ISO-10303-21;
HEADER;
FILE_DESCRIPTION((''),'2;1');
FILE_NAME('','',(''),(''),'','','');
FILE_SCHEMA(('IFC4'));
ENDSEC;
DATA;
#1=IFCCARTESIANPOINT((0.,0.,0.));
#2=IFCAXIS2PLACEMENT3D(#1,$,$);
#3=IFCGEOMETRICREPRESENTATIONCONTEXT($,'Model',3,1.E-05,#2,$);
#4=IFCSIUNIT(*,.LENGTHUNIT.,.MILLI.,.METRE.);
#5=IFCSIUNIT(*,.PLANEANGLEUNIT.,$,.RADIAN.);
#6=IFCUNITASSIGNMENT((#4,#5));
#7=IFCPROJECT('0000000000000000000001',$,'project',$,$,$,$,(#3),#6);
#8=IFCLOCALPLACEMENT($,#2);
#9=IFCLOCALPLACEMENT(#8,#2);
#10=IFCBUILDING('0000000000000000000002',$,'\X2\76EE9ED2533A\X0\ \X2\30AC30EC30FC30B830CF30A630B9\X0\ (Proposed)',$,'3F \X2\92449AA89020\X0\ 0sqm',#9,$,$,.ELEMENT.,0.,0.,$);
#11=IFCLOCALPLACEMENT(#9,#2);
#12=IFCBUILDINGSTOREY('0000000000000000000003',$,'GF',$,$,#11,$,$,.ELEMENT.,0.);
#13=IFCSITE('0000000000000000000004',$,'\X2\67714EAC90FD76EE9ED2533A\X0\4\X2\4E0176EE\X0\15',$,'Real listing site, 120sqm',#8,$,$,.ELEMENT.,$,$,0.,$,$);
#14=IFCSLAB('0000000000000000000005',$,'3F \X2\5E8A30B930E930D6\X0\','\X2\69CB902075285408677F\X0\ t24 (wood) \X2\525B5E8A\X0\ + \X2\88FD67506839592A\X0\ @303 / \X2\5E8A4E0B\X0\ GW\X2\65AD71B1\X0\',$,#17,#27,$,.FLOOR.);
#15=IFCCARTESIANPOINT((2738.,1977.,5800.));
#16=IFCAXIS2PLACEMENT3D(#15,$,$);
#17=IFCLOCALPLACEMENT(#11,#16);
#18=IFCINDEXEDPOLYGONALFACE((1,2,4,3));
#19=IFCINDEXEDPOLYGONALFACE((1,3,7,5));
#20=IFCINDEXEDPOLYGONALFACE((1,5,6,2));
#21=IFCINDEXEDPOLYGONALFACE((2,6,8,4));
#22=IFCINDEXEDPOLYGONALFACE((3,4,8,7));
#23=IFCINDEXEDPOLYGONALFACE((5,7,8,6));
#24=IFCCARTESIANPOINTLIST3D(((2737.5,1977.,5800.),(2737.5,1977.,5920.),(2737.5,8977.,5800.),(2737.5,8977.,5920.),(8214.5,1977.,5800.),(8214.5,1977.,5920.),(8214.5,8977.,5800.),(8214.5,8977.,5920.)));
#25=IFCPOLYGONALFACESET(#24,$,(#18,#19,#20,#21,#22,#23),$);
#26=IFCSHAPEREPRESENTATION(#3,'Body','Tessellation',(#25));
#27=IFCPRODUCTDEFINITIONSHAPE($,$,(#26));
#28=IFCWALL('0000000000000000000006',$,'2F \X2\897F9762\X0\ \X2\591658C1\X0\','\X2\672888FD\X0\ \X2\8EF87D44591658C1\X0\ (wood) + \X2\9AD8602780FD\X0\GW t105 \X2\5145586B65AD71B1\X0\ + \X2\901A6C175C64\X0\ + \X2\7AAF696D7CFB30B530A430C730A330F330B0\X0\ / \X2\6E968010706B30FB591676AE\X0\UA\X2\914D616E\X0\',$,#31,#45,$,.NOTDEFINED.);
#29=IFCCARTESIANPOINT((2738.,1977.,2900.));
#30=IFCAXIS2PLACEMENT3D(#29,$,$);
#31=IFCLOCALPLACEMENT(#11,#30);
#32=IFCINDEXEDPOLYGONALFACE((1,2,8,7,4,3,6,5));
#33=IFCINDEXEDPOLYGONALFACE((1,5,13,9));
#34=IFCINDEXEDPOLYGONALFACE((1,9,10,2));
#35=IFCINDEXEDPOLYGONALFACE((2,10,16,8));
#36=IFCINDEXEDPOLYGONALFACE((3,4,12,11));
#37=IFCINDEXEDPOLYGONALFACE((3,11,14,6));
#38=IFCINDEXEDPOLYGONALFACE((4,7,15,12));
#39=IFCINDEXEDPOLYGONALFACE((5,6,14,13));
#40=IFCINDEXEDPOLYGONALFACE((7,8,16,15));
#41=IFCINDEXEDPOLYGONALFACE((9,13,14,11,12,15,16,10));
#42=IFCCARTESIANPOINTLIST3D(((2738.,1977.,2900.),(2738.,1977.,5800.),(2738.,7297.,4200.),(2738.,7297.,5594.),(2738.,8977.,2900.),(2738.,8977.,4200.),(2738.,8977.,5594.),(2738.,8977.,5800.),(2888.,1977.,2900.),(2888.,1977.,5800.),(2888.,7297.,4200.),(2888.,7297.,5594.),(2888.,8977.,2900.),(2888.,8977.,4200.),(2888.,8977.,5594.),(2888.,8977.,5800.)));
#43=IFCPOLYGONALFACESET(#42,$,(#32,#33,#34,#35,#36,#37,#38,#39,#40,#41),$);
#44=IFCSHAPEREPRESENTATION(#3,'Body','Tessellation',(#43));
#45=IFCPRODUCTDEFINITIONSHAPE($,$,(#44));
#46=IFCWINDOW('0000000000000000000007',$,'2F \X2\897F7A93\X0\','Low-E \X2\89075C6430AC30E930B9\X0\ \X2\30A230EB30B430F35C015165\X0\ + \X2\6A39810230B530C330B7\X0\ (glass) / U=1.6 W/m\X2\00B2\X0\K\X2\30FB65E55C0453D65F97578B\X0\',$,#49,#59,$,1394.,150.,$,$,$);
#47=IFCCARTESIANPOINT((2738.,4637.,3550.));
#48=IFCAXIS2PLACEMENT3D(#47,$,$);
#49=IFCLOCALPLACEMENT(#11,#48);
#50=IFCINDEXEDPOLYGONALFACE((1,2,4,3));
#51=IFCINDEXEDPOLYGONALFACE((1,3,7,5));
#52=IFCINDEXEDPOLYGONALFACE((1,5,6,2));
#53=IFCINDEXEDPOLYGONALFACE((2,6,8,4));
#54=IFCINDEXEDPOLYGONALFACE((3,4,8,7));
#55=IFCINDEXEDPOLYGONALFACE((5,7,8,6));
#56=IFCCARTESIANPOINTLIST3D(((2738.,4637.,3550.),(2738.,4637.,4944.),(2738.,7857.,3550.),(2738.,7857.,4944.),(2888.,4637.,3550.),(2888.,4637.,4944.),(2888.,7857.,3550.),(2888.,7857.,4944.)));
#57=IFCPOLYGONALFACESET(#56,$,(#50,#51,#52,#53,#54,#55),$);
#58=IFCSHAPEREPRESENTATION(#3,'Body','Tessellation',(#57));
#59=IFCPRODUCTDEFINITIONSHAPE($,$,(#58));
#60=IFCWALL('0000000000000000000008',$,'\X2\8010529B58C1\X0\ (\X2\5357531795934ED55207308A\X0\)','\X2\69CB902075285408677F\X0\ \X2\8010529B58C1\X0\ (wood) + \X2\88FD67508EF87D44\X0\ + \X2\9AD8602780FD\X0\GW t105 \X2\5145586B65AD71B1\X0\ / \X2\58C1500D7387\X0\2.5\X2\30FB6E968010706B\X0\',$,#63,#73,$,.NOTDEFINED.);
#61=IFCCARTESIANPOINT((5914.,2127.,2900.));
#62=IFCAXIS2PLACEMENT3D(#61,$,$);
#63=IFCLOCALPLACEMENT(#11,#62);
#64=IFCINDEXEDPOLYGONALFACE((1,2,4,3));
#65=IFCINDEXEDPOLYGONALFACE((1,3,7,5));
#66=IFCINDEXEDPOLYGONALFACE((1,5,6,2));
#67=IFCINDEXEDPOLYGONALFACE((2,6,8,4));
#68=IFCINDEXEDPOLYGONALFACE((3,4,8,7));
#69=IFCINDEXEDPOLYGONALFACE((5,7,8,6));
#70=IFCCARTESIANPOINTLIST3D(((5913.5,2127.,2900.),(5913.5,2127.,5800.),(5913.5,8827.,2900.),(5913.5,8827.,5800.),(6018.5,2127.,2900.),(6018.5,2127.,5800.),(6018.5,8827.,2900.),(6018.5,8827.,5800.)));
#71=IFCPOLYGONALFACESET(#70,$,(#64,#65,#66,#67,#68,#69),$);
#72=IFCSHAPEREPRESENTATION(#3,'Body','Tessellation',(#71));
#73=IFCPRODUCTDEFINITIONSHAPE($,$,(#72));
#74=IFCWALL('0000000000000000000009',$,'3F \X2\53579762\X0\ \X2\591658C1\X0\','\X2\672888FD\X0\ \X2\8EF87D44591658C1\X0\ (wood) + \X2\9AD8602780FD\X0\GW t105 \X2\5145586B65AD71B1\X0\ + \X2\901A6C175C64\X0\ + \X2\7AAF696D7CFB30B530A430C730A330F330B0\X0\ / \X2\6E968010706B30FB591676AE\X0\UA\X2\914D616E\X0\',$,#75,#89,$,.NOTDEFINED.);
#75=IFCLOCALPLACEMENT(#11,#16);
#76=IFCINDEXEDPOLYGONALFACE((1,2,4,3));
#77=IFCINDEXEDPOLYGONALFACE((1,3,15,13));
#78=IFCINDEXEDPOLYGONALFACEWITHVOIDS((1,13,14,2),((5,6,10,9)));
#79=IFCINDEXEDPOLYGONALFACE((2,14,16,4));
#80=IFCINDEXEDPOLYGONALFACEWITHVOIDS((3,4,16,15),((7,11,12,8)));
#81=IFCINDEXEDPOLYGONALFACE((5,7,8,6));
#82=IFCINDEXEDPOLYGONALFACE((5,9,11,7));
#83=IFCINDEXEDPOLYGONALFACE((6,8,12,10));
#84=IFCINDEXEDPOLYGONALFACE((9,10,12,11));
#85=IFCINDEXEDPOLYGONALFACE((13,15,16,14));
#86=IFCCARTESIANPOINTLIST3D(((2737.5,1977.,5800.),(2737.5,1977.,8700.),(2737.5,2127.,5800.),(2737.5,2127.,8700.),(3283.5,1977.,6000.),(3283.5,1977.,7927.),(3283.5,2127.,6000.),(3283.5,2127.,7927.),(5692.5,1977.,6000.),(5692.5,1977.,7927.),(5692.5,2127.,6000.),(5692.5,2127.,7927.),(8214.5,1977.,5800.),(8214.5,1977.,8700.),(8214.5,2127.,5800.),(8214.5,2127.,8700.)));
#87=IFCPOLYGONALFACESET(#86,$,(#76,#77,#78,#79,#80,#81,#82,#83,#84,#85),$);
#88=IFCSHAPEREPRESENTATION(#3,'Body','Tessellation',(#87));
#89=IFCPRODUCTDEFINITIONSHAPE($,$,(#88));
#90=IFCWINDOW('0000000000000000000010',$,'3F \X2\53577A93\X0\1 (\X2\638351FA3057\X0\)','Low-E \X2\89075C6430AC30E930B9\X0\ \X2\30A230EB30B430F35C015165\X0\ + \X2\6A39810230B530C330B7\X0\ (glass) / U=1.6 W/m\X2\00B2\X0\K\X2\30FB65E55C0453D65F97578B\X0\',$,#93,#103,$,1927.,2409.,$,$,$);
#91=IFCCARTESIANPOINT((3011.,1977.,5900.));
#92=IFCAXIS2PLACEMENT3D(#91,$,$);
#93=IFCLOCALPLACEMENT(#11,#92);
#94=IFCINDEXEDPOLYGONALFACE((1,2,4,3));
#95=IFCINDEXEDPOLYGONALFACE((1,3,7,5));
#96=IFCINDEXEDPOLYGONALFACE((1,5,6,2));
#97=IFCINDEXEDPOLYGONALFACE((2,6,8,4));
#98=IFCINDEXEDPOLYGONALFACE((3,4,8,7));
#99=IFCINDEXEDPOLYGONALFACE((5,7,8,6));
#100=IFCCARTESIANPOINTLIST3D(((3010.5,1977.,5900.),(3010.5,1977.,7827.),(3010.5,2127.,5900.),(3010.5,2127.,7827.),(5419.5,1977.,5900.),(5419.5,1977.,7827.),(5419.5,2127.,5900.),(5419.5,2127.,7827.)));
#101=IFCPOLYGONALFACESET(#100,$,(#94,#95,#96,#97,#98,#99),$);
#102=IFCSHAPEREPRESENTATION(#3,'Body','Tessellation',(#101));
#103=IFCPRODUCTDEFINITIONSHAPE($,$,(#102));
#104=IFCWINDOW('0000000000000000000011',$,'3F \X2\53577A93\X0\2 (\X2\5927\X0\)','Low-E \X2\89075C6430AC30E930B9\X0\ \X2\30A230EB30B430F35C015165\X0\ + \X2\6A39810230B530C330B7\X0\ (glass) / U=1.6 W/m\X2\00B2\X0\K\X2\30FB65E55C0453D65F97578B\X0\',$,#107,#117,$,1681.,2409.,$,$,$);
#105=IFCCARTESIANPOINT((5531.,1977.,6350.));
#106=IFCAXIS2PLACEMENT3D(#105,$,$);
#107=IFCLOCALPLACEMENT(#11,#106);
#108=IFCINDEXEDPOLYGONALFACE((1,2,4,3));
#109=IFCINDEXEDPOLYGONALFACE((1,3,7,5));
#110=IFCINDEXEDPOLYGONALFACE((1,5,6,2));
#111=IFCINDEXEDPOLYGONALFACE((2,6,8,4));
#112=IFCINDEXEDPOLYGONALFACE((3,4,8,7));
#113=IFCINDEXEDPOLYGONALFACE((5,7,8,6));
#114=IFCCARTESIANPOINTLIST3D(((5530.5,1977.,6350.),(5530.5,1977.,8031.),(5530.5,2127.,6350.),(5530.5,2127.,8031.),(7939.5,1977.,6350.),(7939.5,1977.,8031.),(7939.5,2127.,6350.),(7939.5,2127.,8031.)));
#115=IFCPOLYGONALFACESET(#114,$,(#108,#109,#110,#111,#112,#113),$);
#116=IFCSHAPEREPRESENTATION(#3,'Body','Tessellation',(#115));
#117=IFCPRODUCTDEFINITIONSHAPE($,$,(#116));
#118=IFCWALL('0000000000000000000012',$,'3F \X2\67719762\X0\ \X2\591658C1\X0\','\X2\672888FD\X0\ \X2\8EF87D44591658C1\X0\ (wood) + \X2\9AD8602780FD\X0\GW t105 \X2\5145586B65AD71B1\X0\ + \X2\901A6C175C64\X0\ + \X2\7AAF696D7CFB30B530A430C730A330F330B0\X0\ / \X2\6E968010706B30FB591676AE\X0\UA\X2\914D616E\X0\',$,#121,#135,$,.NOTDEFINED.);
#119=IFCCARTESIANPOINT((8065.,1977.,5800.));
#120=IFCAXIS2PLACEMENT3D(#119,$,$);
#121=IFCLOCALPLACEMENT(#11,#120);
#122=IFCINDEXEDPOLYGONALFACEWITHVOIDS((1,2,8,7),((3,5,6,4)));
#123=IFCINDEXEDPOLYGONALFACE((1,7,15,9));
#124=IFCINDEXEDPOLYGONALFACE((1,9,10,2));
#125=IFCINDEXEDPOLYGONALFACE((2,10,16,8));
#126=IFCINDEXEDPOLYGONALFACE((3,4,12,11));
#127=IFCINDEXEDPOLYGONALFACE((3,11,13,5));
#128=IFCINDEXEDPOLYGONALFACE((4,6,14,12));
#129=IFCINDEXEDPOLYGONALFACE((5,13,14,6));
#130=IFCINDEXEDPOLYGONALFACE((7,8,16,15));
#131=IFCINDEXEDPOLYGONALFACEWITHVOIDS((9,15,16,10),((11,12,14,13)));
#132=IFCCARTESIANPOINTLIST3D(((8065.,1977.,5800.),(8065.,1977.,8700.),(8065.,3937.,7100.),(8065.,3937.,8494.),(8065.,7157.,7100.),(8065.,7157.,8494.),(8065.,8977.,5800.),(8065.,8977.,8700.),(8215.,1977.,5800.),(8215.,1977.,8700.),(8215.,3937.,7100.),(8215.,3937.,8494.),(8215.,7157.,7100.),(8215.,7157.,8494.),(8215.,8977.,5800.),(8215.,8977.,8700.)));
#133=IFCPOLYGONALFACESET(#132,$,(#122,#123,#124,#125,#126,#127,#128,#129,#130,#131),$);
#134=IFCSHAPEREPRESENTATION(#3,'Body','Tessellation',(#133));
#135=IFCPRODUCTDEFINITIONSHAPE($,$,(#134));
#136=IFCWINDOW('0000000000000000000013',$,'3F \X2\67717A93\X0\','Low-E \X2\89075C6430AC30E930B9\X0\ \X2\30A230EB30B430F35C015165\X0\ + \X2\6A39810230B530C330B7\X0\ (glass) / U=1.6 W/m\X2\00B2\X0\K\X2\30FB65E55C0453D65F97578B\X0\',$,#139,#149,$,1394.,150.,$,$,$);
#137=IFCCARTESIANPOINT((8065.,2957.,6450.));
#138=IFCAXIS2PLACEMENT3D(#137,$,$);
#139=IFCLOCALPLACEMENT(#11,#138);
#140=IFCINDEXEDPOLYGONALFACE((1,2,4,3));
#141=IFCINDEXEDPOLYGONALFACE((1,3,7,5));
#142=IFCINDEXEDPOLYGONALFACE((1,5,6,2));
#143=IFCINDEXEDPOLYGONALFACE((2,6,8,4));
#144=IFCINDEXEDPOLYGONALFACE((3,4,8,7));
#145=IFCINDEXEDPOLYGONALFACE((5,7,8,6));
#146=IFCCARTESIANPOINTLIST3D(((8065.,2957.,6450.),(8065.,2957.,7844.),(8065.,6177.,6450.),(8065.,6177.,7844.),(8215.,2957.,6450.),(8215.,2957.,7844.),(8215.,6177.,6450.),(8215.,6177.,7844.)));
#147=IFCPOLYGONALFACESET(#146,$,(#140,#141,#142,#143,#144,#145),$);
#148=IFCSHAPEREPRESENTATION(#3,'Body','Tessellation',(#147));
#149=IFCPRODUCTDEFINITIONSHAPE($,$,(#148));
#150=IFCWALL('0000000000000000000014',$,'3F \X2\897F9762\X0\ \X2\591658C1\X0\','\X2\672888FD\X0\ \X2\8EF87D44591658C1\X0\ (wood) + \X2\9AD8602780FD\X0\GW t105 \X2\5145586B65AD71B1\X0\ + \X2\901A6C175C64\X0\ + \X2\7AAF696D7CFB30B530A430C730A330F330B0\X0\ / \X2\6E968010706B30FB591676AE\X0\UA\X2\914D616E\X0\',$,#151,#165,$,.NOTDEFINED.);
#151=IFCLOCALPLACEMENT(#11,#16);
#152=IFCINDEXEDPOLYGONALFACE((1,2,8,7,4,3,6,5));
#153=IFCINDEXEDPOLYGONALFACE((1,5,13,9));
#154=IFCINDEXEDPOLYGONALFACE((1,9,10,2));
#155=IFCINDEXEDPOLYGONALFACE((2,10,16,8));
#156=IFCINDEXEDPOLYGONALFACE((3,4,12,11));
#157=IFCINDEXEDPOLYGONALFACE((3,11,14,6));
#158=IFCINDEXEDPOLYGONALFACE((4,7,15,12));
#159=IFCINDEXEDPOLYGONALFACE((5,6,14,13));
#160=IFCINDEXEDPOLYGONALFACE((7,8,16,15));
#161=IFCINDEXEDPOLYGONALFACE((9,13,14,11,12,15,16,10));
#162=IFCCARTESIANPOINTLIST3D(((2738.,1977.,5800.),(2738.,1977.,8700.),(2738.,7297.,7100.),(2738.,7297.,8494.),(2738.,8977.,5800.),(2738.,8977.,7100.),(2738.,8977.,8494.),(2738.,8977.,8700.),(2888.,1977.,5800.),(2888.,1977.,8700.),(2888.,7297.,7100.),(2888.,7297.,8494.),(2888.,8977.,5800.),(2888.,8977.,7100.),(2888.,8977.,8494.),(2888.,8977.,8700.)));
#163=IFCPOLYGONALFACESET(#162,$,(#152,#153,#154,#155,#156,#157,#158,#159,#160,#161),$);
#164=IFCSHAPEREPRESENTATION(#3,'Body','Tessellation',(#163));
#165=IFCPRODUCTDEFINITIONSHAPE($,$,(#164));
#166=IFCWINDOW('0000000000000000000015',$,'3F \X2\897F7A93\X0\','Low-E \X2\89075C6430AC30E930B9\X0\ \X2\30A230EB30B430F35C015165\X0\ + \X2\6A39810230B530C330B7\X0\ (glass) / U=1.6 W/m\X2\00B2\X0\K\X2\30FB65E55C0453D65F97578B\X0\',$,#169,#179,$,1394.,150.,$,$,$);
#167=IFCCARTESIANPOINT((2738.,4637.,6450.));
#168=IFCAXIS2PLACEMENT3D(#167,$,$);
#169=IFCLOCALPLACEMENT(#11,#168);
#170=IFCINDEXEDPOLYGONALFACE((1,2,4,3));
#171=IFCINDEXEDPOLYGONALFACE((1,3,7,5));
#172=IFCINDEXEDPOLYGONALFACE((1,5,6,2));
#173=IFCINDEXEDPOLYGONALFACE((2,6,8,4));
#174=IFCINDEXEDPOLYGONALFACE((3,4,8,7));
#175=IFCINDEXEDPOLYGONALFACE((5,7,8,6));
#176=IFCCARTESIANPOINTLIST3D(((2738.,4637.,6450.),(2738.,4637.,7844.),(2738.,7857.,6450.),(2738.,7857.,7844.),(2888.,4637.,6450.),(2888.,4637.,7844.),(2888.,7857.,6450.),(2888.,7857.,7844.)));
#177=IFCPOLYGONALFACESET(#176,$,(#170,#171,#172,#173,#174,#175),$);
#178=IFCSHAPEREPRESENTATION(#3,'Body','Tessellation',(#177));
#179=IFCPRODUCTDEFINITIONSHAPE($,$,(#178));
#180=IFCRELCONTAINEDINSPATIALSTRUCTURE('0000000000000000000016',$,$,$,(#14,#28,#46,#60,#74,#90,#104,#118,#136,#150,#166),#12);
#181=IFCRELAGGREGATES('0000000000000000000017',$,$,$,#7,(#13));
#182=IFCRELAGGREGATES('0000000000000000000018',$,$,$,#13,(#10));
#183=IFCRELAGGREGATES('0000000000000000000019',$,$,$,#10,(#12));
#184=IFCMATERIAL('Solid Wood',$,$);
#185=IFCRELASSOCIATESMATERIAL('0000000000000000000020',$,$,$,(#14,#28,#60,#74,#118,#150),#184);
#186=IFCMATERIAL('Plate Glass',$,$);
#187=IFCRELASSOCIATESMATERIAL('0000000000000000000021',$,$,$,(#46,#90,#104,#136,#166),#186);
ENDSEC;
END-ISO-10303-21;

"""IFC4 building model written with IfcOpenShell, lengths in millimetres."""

from ifc_helpers import new_model, si_unit, frame, frame_2d, origin, place, context, project, spatial, rectangle, extrude, material, element, fill, save


model = new_model("IFC4")

# Units and contexts
model_context = context("Model", 3, precision=1e-05, world=origin())
ifc_project = project(units=[si_unit("LENGTHUNIT", "METRE", prefix="MILLI"), si_unit("PLANEANGLEUNIT", "RADIAN")], contexts=[model_context])

# Site, building, storey
site_placement = place(None, origin())
site = spatial("IfcSite", under=ifc_project, at=site_placement, Name="東京都目黒区4丁目15", ObjectType="Real listing site, 120sqm", CompositionType="ELEMENT", RefElevation=0.0)
building_placement = place(site_placement, origin())
building = spatial("IfcBuilding", under=site, at=building_placement, Name="目黒区 ガレージハウス (Proposed)", ObjectType="3F 鉄骨造 0sqm", CompositionType="ELEMENT", ElevationOfRefHeight=0.0, ElevationOfTerrain=0.0)
storey_placement = place(building_placement, origin())
storey = spatial("IfcBuildingStorey", under=building, at=storey_placement, Name="GF", CompositionType="ELEMENT", Elevation=0.0)

# Slab
ifc_material_1 = material(Name="Solid Wood")
slab_placement = place(storey_placement, frame((2738.0, 1977.0, 5800.0)))
element("IfcSlab", 1, at=slab_placement, inside=storey, material=ifc_material_1, Name="3F 床スラブ", Description="構造用合板 t24 (wood) 剛床 + 製材根太 @303 / 床下 GW断熱", PredefinedType="FLOOR", context=model_context, shape_type="SweptSolid", body=[
    extrude(rectangle(XDim=5477.0, YDim=7000.0, at=frame_2d((2738.0, 3500.0))), frame((2738.0, 1977.0, 5800.0)), (0.0, 0.0, 1.0), 120.0),
])

# Wall, opening, window
wall_1_placement = place(storey_placement, frame((2738.0, 1977.0, 2900.0)))
wall_1 = element("IfcWall", 2, at=wall_1_placement, inside=storey, material=ifc_material_1, Name="2F 西面 外壁", Description="木製 軸組外壁 (wood) + 高性能GW t105 充填断熱 + 通気層 + 窯業系サイディング / 準耐火・外皮UA配慮", PredefinedType="NOTDEFINED", context=model_context, shape_type="SweptSolid", body=[
    extrude(rectangle(XDim=150.0, YDim=7000.0, at=frame_2d((75.0, 3500.0))), frame((2738.0, 1977.0, 2900.0)), (0.0, 0.0, 1.0), 2900.0),
])
opening_1_placement = place(storey_placement, frame((2738.0, 4637.0, 3550.0)))
opening_1 = element("IfcOpeningElement", 3, at=opening_1_placement, cuts=wall_1, PredefinedType="NOTDEFINED", context=model_context, shape_type="SweptSolid", body=[
    extrude(rectangle(XDim=150.0, YDim=3220.0, at=frame_2d((75.0, 1610.0))), frame((2738.0, 4637.0, 3550.0)), (0.0, 0.0, 1.0), 1394.0),
])
ifc_material_2 = material(Name="Plate Glass")
window_1_placement = place(storey_placement, frame((2738.0, 4637.0, 3550.0)))
window_1 = element("IfcWindow", 4, at=window_1_placement, inside=storey, material=ifc_material_2, Name="2F 西窓", Description="Low-E 複層ガラス アルゴン封入 + 樹脂サッシ (glass) / U=1.6 W/m²K・日射取得型", OverallHeight=1394.0, OverallWidth=150.0, context=model_context, shape_type="SweptSolid", body=[
    extrude(rectangle(XDim=150.0, YDim=3220.0, at=frame_2d((75.0, 1610.0))), frame((2738.0, 4637.0, 3550.0)), (0.0, 0.0, 1.0), 1394.0),
])
fill(opening_1, window_1)

# Wall
wall_2_placement = place(storey_placement, frame((5914.0, 2127.0, 2900.0)))
element("IfcWall", 5, at=wall_2_placement, inside=storey, material=ifc_material_1, Name="耐力壁 (南北間仕切り)", Description="構造用合板 耐力壁 (wood) + 製材軸組 + 高性能GW t105 充填断熱 / 壁倍率2.5・準耐火", PredefinedType="NOTDEFINED", context=model_context, shape_type="SweptSolid", body=[
    extrude(rectangle(XDim=105.0, YDim=6700.0, at=frame_2d((52.0, 3350.0))), frame((5914.0, 2127.0, 2900.0)), (0.0, 0.0, 1.0), 2900.0),
])

# Wall, openings, windows
wall_3_placement = place(storey_placement, frame((2738.0, 1977.0, 5800.0)))
wall_3 = element("IfcWall", 6, at=wall_3_placement, inside=storey, material=ifc_material_1, Name="3F 南面 外壁", Description="木製 軸組外壁 (wood) + 高性能GW t105 充填断熱 + 通気層 + 窯業系サイディング / 準耐火・外皮UA配慮", PredefinedType="NOTDEFINED", context=model_context, shape_type="SweptSolid", body=[
    extrude(rectangle(XDim=5477.0, YDim=150.0, at=frame_2d((2738.0, 75.0))), frame((2738.0, 1977.0, 5800.0)), (0.0, 0.0, 1.0), 2900.0),
])
opening_2_placement = place(storey_placement, frame((3011.0, 1977.0, 5900.0)))
opening_2 = element("IfcOpeningElement", 7, at=opening_2_placement, cuts=wall_3, PredefinedType="NOTDEFINED", context=model_context, shape_type="SweptSolid", body=[
    extrude(rectangle(XDim=2409.0, YDim=150.0, at=frame_2d((1204.0, 75.0))), frame((3011.0, 1977.0, 5900.0)), (0.0, 0.0, 1.0), 1927.0),
])
opening_3_placement = place(storey_placement, frame((5531.0, 1977.0, 6350.0)))
opening_3 = element("IfcOpeningElement", 8, at=opening_3_placement, cuts=wall_3, PredefinedType="NOTDEFINED", context=model_context, shape_type="SweptSolid", body=[
    extrude(rectangle(XDim=2409.0, YDim=150.0, at=frame_2d((1204.0, 75.0))), frame((5531.0, 1977.0, 6350.0)), (0.0, 0.0, 1.0), 1681.0),
])
window_2_placement = place(storey_placement, frame((3011.0, 1977.0, 5900.0)))
window_2 = element("IfcWindow", 9, at=window_2_placement, inside=storey, material=ifc_material_2, Name="3F 南窓1 (掃出し)", Description="Low-E 複層ガラス アルゴン封入 + 樹脂サッシ (glass) / U=1.6 W/m²K・日射取得型", OverallHeight=1927.0, OverallWidth=2409.0, context=model_context, shape_type="SweptSolid", body=[
    extrude(rectangle(XDim=2409.0, YDim=150.0, at=frame_2d((1204.0, 75.0))), frame((3011.0, 1977.0, 5900.0)), (0.0, 0.0, 1.0), 1927.0),
])
fill(opening_2, window_2)
window_3_placement = place(storey_placement, frame((5531.0, 1977.0, 6350.0)))
window_3 = element("IfcWindow", 10, at=window_3_placement, inside=storey, material=ifc_material_2, Name="3F 南窓2 (大)", Description="Low-E 複層ガラス アルゴン封入 + 樹脂サッシ (glass) / U=1.6 W/m²K・日射取得型", OverallHeight=1681.0, OverallWidth=2409.0, context=model_context, shape_type="SweptSolid", body=[
    extrude(rectangle(XDim=2409.0, YDim=150.0, at=frame_2d((1204.0, 75.0))), frame((5531.0, 1977.0, 6350.0)), (0.0, 0.0, 1.0), 1681.0),
])
fill(opening_3, window_3)

# Walls, openings, windows
wall_4_placement = place(storey_placement, frame((8065.0, 1977.0, 5800.0)))
wall_4 = element("IfcWall", 11, at=wall_4_placement, inside=storey, material=ifc_material_1, Name="3F 東面 外壁", Description="木製 軸組外壁 (wood) + 高性能GW t105 充填断熱 + 通気層 + 窯業系サイディング / 準耐火・外皮UA配慮", PredefinedType="NOTDEFINED", context=model_context, shape_type="SweptSolid", body=[
    extrude(rectangle(XDim=150.0, YDim=7000.0, at=frame_2d((75.0, 3500.0))), frame((8065.0, 1977.0, 5800.0)), (0.0, 0.0, 1.0), 2900.0),
])
opening_4_placement = place(storey_placement, frame((8065.0, 2957.0, 6450.0)))
opening_4 = element("IfcOpeningElement", 12, at=opening_4_placement, cuts=wall_4, PredefinedType="NOTDEFINED", context=model_context, shape_type="SweptSolid", body=[
    extrude(rectangle(XDim=150.0, YDim=3220.0, at=frame_2d((75.0, 1610.0))), frame((8065.0, 2957.0, 6450.0)), (0.0, 0.0, 1.0), 1394.0),
])
window_4_placement = place(storey_placement, frame((8065.0, 2957.0, 6450.0)))
window_4 = element("IfcWindow", 13, at=window_4_placement, inside=storey, material=ifc_material_2, Name="3F 東窓", Description="Low-E 複層ガラス アルゴン封入 + 樹脂サッシ (glass) / U=1.6 W/m²K・日射取得型", OverallHeight=1394.0, OverallWidth=150.0, context=model_context, shape_type="SweptSolid", body=[
    extrude(rectangle(XDim=150.0, YDim=3220.0, at=frame_2d((75.0, 1610.0))), frame((8065.0, 2957.0, 6450.0)), (0.0, 0.0, 1.0), 1394.0),
])
fill(opening_4, window_4)
wall_5_placement = place(storey_placement, frame((2738.0, 1977.0, 5800.0)))
wall_5 = element("IfcWall", 14, at=wall_5_placement, inside=storey, material=ifc_material_1, Name="3F 西面 外壁", Description="木製 軸組外壁 (wood) + 高性能GW t105 充填断熱 + 通気層 + 窯業系サイディング / 準耐火・外皮UA配慮", PredefinedType="NOTDEFINED", context=model_context, shape_type="SweptSolid", body=[
    extrude(rectangle(XDim=150.0, YDim=7000.0, at=frame_2d((75.0, 3500.0))), frame((2738.0, 1977.0, 5800.0)), (0.0, 0.0, 1.0), 2900.0),
])
opening_5_placement = place(storey_placement, frame((2738.0, 4637.0, 6450.0)))
opening_5 = element("IfcOpeningElement", 15, at=opening_5_placement, cuts=wall_5, PredefinedType="NOTDEFINED", context=model_context, shape_type="SweptSolid", body=[
    extrude(rectangle(XDim=150.0, YDim=3220.0, at=frame_2d((75.0, 1610.0))), frame((2738.0, 4637.0, 6450.0)), (0.0, 0.0, 1.0), 1394.0),
])
window_5_placement = place(storey_placement, frame((2738.0, 4637.0, 6450.0)))
window_5 = element("IfcWindow", 16, at=window_5_placement, inside=storey, material=ifc_material_2, Name="3F 西窓", Description="Low-E 複層ガラス アルゴン封入 + 樹脂サッシ (glass) / U=1.6 W/m²K・日射取得型", OverallHeight=1394.0, OverallWidth=150.0, context=model_context, shape_type="SweptSolid", body=[
    extrude(rectangle(XDim=150.0, YDim=3220.0, at=frame_2d((75.0, 1610.0))), frame((2738.0, 4637.0, 6450.0)), (0.0, 0.0, 1.0), 1394.0),
])
fill(opening_5, window_5)

save(model, "model.ifc")
